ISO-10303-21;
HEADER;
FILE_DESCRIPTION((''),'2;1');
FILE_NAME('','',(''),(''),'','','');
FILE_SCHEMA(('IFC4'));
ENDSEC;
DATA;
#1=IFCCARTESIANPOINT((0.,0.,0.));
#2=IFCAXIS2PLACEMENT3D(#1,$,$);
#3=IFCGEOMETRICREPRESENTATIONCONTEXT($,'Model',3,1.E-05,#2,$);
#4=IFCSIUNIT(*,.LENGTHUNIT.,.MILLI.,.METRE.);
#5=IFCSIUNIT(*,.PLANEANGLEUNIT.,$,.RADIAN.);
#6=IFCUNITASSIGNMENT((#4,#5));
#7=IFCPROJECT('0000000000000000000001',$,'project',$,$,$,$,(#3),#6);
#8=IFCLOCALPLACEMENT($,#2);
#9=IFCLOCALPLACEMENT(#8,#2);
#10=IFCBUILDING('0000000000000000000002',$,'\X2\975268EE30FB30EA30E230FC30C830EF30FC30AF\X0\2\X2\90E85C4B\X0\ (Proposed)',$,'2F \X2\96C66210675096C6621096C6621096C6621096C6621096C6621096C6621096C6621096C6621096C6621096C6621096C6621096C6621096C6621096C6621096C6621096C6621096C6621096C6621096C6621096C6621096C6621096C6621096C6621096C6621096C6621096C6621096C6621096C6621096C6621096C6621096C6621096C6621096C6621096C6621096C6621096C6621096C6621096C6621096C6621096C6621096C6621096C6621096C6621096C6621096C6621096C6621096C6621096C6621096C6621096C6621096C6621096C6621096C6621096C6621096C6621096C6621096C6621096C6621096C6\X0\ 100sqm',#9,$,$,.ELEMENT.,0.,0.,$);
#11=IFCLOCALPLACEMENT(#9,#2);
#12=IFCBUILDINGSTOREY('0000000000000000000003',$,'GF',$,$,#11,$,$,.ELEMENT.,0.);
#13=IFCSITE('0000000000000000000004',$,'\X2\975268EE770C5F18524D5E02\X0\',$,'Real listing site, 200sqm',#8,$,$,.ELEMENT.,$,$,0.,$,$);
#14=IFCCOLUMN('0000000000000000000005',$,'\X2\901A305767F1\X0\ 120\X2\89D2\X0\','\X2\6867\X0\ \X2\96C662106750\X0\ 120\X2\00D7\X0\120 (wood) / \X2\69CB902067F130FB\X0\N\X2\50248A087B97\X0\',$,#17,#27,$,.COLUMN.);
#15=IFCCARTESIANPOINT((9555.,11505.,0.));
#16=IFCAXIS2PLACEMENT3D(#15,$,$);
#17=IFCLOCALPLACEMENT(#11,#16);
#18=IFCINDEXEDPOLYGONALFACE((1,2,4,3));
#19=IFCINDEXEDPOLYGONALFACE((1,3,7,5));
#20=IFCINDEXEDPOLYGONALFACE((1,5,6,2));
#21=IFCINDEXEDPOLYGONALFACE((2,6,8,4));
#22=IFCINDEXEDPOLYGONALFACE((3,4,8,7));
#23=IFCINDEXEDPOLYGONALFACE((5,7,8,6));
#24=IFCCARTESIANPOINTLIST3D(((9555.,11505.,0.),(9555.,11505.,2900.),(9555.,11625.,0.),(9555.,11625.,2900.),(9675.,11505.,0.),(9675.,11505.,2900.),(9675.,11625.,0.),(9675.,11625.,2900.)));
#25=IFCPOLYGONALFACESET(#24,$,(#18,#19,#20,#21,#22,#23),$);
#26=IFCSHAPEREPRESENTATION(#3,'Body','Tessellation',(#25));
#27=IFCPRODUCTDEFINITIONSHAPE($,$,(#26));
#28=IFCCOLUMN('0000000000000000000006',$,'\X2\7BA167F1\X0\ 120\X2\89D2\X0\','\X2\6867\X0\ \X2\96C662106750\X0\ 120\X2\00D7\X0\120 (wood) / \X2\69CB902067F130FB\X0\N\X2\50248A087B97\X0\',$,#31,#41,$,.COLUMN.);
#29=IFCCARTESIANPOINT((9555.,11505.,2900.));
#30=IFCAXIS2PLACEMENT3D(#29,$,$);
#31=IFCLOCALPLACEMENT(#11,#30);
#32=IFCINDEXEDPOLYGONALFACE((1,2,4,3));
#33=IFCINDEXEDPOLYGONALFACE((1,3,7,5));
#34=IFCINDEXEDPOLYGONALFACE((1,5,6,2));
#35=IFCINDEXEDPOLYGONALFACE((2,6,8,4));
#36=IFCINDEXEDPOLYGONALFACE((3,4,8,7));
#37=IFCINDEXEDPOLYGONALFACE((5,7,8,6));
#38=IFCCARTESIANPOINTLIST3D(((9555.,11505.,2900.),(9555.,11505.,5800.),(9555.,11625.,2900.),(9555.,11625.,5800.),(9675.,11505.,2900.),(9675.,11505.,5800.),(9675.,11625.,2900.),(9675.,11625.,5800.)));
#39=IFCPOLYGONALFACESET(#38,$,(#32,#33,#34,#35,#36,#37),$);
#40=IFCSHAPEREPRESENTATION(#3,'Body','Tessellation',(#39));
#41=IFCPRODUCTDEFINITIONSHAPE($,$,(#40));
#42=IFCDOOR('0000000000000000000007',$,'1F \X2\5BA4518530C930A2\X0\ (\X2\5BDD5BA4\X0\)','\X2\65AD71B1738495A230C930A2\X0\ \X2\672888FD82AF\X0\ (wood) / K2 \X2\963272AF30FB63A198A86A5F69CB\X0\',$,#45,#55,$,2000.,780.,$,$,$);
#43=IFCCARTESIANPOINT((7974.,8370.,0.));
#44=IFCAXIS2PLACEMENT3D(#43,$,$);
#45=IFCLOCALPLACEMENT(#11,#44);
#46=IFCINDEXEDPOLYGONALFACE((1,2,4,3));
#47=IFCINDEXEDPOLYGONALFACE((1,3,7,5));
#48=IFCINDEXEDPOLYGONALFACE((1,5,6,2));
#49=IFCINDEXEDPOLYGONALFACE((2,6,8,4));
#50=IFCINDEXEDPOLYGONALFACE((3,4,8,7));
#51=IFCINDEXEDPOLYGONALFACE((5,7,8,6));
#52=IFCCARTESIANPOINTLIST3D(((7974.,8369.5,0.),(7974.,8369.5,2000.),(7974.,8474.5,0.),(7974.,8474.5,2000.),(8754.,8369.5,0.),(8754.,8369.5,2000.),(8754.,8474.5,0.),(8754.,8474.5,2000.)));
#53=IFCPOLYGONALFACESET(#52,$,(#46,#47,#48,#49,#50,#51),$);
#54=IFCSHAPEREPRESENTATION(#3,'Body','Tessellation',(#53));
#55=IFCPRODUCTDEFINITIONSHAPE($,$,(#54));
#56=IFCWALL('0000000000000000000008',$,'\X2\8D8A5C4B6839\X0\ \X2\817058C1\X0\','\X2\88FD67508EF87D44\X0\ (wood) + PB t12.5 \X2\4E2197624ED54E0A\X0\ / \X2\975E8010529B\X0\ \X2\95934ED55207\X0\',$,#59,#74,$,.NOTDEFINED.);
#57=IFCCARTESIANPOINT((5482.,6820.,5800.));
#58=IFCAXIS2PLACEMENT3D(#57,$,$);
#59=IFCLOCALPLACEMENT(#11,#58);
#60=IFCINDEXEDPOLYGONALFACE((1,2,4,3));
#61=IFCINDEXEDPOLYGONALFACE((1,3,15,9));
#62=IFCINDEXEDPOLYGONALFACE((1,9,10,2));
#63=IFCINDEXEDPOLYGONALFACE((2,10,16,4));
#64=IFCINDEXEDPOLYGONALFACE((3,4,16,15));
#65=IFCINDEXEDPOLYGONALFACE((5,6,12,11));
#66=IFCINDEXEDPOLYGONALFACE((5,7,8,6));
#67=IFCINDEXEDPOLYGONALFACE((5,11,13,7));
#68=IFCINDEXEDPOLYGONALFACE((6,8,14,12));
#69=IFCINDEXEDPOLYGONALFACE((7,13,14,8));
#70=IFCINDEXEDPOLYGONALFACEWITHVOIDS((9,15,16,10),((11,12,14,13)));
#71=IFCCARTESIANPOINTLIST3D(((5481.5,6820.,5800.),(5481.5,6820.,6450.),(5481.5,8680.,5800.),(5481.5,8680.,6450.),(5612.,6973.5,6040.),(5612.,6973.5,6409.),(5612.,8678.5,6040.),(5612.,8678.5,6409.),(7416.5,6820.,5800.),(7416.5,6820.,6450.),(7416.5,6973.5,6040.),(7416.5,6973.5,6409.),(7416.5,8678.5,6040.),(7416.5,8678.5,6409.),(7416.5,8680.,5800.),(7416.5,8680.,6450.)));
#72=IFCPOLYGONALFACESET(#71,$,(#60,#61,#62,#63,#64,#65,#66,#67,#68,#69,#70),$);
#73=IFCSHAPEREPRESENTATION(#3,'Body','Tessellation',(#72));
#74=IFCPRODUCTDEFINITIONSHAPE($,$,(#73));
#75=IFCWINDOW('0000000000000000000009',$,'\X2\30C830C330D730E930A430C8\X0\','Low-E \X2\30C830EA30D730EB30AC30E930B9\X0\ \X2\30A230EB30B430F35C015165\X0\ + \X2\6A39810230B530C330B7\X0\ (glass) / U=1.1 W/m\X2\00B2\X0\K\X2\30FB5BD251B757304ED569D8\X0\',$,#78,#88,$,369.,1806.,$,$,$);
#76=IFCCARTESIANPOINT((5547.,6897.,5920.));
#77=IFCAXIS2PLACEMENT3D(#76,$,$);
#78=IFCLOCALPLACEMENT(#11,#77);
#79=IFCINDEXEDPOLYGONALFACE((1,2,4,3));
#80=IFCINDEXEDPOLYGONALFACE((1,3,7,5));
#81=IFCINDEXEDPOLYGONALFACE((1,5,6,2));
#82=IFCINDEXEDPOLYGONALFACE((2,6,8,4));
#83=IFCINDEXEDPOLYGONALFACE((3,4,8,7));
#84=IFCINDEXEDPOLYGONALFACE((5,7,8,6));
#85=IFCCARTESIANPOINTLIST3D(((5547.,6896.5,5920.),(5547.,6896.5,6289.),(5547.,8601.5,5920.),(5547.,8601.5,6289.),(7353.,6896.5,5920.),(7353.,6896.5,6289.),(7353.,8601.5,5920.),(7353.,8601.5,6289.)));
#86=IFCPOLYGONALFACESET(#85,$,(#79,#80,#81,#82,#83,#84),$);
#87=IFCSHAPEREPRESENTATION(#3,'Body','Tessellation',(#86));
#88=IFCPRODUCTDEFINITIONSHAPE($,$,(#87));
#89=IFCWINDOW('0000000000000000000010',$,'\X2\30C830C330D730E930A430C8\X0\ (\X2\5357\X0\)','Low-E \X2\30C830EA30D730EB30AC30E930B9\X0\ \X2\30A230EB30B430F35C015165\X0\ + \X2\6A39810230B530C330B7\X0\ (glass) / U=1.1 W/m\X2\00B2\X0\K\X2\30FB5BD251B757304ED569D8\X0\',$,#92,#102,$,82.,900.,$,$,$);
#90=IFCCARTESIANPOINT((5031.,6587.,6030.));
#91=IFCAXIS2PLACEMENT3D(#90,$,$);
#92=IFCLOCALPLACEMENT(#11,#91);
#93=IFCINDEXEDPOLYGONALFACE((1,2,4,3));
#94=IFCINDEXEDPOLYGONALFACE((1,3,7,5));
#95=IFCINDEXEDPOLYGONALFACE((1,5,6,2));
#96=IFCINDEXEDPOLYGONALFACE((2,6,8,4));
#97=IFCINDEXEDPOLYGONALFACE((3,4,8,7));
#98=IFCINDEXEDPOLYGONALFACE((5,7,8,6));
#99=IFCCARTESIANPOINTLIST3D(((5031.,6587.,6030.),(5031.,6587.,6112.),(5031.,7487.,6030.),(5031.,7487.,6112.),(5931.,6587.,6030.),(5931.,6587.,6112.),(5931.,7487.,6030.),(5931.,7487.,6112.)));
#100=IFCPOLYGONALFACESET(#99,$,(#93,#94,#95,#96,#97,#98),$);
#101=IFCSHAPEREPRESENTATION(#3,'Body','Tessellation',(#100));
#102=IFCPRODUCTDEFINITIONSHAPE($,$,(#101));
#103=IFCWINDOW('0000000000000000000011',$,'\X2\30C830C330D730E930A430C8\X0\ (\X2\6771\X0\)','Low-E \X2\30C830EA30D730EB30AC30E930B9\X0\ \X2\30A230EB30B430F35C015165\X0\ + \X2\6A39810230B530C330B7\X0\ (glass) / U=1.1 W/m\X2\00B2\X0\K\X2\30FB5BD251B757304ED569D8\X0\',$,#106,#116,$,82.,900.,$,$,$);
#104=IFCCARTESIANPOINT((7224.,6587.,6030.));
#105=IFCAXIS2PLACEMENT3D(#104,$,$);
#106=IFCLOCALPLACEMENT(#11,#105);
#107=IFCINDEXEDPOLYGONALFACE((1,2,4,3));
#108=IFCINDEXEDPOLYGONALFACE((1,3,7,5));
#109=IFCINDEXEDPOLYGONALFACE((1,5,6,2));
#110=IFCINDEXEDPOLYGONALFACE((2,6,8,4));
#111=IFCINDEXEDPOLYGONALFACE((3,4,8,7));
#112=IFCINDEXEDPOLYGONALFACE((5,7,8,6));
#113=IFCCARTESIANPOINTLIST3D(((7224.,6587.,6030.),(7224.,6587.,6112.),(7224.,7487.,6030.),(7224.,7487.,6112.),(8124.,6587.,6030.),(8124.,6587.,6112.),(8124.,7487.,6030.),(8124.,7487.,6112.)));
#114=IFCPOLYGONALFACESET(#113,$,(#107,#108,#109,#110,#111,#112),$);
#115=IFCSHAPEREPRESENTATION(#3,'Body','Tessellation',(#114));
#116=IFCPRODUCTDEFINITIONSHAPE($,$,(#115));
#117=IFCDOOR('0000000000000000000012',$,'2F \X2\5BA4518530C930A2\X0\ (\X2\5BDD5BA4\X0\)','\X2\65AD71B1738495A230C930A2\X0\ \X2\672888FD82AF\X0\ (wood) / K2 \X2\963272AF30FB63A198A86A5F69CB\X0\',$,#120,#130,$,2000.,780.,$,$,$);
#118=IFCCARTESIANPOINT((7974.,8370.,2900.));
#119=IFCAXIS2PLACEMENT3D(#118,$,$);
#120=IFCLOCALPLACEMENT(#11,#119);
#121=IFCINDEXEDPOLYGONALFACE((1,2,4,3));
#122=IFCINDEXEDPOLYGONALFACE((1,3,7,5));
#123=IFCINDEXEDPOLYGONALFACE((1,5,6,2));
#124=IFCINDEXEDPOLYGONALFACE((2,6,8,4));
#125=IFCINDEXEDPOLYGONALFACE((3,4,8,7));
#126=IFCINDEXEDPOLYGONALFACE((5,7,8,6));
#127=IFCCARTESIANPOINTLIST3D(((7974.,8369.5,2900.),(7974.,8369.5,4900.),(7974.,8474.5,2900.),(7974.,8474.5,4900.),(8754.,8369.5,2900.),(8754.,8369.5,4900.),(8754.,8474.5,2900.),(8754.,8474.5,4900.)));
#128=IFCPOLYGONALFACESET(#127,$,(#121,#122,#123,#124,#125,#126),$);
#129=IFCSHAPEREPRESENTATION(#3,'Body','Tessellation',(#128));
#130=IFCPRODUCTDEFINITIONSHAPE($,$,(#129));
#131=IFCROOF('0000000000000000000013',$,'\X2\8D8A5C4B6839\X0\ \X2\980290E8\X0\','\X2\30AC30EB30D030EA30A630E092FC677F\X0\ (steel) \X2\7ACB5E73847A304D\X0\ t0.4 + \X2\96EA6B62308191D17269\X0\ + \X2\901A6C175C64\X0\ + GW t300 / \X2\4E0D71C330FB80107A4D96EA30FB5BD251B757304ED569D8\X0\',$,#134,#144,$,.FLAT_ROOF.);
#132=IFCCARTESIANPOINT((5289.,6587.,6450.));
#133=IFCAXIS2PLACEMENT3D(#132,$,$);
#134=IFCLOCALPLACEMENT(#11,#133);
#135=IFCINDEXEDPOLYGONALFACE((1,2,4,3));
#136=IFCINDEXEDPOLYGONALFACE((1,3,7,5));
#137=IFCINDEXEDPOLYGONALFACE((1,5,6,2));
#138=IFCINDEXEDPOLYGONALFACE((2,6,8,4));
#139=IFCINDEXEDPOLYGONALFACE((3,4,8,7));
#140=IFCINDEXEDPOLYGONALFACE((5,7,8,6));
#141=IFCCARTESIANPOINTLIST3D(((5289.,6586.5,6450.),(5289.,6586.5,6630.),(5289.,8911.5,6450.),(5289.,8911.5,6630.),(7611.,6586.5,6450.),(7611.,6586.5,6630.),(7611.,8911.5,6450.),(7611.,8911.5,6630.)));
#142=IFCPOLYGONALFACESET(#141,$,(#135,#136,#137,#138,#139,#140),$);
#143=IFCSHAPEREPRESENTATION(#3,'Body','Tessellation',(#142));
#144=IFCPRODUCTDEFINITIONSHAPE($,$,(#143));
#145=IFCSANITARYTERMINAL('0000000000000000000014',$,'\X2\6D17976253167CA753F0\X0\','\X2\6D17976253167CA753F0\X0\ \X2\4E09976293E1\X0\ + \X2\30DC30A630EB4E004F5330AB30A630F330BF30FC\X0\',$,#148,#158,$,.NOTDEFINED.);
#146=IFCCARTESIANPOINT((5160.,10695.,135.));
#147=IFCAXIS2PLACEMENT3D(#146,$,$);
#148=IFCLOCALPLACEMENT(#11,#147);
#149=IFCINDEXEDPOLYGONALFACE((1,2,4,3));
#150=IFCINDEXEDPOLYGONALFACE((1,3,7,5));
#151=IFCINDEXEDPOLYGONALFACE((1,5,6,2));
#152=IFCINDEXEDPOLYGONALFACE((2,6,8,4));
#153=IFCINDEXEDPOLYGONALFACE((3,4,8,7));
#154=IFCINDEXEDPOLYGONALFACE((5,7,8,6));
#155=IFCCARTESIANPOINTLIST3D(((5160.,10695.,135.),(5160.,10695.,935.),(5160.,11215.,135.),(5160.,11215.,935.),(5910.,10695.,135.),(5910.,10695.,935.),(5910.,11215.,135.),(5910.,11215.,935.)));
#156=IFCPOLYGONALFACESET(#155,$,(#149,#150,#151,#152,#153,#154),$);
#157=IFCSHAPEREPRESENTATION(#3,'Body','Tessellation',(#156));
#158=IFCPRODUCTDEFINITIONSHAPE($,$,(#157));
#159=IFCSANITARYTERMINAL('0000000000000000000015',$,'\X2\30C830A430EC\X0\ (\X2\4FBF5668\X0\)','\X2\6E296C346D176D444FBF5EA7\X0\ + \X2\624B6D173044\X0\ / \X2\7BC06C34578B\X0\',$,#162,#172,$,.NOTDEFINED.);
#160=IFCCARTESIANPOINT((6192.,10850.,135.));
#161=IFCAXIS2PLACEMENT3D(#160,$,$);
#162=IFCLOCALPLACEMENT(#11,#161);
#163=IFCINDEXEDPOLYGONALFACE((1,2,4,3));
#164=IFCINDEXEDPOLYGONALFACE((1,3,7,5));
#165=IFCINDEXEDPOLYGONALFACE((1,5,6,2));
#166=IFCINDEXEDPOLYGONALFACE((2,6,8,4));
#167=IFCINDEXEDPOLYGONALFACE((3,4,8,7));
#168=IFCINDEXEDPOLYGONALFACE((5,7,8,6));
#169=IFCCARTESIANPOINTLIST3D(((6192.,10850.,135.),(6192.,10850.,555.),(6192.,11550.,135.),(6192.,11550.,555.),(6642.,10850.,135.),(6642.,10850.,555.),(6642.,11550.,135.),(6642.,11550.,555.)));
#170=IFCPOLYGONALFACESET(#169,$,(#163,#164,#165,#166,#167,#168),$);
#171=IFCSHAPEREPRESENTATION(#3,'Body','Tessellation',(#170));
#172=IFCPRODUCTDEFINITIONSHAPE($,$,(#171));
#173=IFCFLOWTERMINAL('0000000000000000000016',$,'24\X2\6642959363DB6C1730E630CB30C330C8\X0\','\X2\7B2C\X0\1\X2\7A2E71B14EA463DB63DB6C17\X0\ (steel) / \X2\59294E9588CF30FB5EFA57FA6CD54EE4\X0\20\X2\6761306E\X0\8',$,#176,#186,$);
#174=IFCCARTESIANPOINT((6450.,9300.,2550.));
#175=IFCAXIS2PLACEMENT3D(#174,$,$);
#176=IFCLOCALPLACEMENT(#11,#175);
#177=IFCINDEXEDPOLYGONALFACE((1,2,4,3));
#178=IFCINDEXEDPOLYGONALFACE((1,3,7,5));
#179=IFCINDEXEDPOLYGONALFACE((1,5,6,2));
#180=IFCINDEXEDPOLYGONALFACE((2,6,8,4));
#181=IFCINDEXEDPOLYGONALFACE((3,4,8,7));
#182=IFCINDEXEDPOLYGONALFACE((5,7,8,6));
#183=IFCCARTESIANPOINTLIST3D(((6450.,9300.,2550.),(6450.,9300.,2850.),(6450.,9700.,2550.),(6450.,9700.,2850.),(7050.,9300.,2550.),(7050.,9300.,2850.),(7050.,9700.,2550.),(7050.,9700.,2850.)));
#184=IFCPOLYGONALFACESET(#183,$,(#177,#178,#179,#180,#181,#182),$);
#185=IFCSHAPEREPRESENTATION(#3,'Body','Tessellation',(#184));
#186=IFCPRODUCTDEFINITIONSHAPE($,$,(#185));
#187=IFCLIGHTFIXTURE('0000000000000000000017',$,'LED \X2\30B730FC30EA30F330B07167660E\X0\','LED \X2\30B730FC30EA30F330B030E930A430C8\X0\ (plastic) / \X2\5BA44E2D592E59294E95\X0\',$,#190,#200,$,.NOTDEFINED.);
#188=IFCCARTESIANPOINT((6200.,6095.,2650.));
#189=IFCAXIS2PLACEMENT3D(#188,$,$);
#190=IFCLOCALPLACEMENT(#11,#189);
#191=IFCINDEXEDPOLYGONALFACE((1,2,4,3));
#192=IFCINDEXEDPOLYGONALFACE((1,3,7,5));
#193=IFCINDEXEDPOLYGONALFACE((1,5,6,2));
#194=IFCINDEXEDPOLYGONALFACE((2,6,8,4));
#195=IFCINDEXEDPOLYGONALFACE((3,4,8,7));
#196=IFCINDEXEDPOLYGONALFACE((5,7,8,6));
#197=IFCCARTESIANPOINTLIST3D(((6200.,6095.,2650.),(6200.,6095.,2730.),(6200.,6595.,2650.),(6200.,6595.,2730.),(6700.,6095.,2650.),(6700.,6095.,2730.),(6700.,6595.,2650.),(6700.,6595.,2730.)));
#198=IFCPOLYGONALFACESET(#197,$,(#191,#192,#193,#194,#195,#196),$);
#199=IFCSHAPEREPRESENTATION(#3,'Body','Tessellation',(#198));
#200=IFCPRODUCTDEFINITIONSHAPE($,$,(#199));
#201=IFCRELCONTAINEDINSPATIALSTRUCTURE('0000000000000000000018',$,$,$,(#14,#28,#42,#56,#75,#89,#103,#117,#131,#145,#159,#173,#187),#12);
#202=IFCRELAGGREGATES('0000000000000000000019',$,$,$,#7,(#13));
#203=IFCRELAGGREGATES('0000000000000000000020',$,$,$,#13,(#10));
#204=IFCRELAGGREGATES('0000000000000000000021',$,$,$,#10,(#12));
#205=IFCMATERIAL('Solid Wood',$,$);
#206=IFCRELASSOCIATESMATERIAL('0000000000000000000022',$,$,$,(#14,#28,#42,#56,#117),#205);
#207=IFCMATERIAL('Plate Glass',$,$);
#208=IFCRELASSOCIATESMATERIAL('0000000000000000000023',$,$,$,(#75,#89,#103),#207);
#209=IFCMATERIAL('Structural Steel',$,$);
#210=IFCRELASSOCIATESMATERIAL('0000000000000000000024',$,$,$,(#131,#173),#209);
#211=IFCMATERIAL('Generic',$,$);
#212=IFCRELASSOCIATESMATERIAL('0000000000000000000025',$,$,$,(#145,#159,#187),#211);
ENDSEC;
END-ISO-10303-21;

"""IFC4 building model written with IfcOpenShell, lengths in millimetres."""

from ifc_helpers import new_model, si_unit, frame, frame_2d, origin, place, context, project, spatial, rectangle, extrude, material, element, fill, save


model = new_model("IFC4")

# Units and contexts
model_context = context("Model", 3, precision=1e-05, world=origin())
ifc_project = project(units=[si_unit("LENGTHUNIT", "METRE", prefix="MILLI"), si_unit("PLANEANGLEUNIT", "RADIAN")], contexts=[model_context])

# Site, building, storey
site_placement = place(None, origin())
site = spatial("IfcSite", under=ifc_project, at=site_placement, Name="青森県弘前市", ObjectType="Real listing site, 200sqm", CompositionType="ELEMENT", RefElevation=0.0)
building_placement = place(site_placement, origin())
building = spatial("IfcBuilding", under=site, at=building_placement, Name="青森・リモートワーク2部屋 (Proposed)", ObjectType="2F 集成材集成集成集成集成集成集成集成集成集成集成集成集成集成集成集成集成集成集成集成集成集成集成集成集成集成集成集成集成集成集成集成集成集成集成集成集成集成集成集成集成集成集成集成集成集成集成集成集成集成集成集成集成集成集成集成集成集成集成集 100sqm", CompositionType="ELEMENT", ElevationOfRefHeight=0.0, ElevationOfTerrain=0.0)
storey_placement = place(building_placement, origin())
storey = spatial("IfcBuildingStorey", under=building, at=storey_placement, Name="GF", CompositionType="ELEMENT", Elevation=0.0)

# Columns
ifc_material_1 = material(Name="Solid Wood")
column_1_placement = place(storey_placement, frame((9555.0, 11505.0, 0.0)))
element("IfcColumn", 1, at=column_1_placement, inside=storey, material=ifc_material_1, Name="通し柱 120角", Description="桧 集成材 120×120 (wood) / 構造柱・N値計算", PredefinedType="COLUMN", context=model_context, shape_type="SweptSolid", body=[
    extrude(rectangle(XDim=120.0, YDim=120.0, at=frame_2d((60.0, 60.0))), frame((9555.0, 11505.0, 0.0)), (0.0, 0.0, 1.0), 2900.0),
])
column_2_placement = place(storey_placement, frame((9555.0, 11505.0, 2900.0)))
element("IfcColumn", 2, at=column_2_placement, inside=storey, material=ifc_material_1, Name="管柱 120角", Description="桧 集成材 120×120 (wood) / 構造柱・N値計算", PredefinedType="COLUMN", context=model_context, shape_type="SweptSolid", body=[
    extrude(rectangle(XDim=120.0, YDim=120.0, at=frame_2d((60.0, 60.0))), frame((9555.0, 11505.0, 2900.0)), (0.0, 0.0, 1.0), 2900.0),
])

# Door
door_1_placement = place(storey_placement, frame((7974.0, 8370.0, 0.0)))
element("IfcDoor", 3, at=door_1_placement, inside=storey, material=ifc_material_1, Name="1F 室内ドア (寝室)", Description="断熱玄関ドア 木製芯 (wood) / K2 防犯・採風機構", OverallHeight=2000.0, OverallWidth=780.0, context=model_context, shape_type="SweptSolid", body=[
    extrude(rectangle(XDim=780.0, YDim=105.0, at=frame_2d((390.0, 52.0))), frame((7974.0, 8370.0, 0.0)), (0.0, 0.0, 1.0), 2000.0),
])

# Wall, openings, windows
wall_1_placement = place(storey_placement, frame((5482.0, 6820.0, 5800.0)))
wall_1 = element("IfcWall", 4, at=wall_1_placement, inside=storey, material=ifc_material_1, Name="越屋根 腰壁", Description="製材軸組 (wood) + PB t12.5 両面仕上 / 非耐力 間仕切", PredefinedType="NOTDEFINED", context=model_context, shape_type="SweptSolid", body=[
    extrude(rectangle(XDim=1935.0, YDim=1860.0, at=frame_2d((967.0, 930.0))), frame((5482.0, 6820.0, 5800.0)), (0.0, 0.0, 1.0), 650.0),
])
opening_1_placement = place(storey_placement, frame((5547.0, 6897.0, 5920.0)))
opening_1 = element("IfcOpeningElement", 5, at=opening_1_placement, cuts=wall_1, PredefinedType="NOTDEFINED", context=model_context, shape_type="SweptSolid", body=[
    extrude(rectangle(XDim=1806.0, YDim=1705.0, at=frame_2d((903.0, 852.0))), frame((5547.0, 6897.0, 5920.0)), (0.0, 0.0, 1.0), 369.0),
])
opening_2_placement = place(storey_placement, frame((5031.0, 6587.0, 6030.0)))
opening_2 = element("IfcOpeningElement", 6, at=opening_2_placement, cuts=wall_1, PredefinedType="NOTDEFINED", context=model_context, shape_type="SweptSolid", body=[
    extrude(rectangle(XDim=900.0, YDim=900.0, at=frame_2d((450.0, 450.0))), frame((5031.0, 6587.0, 6030.0)), (0.0, 0.0, 1.0), 82.0),
])
opening_3_placement = place(storey_placement, frame((7224.0, 6587.0, 6030.0)))
opening_3 = element("IfcOpeningElement", 7, at=opening_3_placement, cuts=wall_1, PredefinedType="NOTDEFINED", context=model_context, shape_type="SweptSolid", body=[
    extrude(rectangle(XDim=900.0, YDim=900.0, at=frame_2d((450.0, 450.0))), frame((7224.0, 6587.0, 6030.0)), (0.0, 0.0, 1.0), 82.0),
])
ifc_material_2 = material(Name="Plate Glass")
window_1_placement = place(storey_placement, frame((5547.0, 6897.0, 5920.0)))
window_1 = element("IfcWindow", 8, at=window_1_placement, inside=storey, material=ifc_material_2, Name="トップライト", Description="Low-E トリプルガラス アルゴン封入 + 樹脂サッシ (glass) / U=1.1 W/m²K・寒冷地仕様", OverallHeight=369.0, OverallWidth=1806.0, context=model_context, shape_type="SweptSolid", body=[
    extrude(rectangle(XDim=1806.0, YDim=1705.0, at=frame_2d((903.0, 852.0))), frame((5547.0, 6897.0, 5920.0)), (0.0, 0.0, 1.0), 369.0),
])
fill(opening_1, window_1)
window_2_placement = place(storey_placement, frame((5031.0, 6587.0, 6030.0)))
window_2 = element("IfcWindow", 9, at=window_2_placement, inside=storey, material=ifc_material_2, Name="トップライト (南)", Description="Low-E トリプルガラス アルゴン封入 + 樹脂サッシ (glass) / U=1.1 W/m²K・寒冷地仕様", OverallHeight=82.0, OverallWidth=900.0, context=model_context, shape_type="SweptSolid", body=[
    extrude(rectangle(XDim=900.0, YDim=900.0, at=frame_2d((450.0, 450.0))), frame((5031.0, 6587.0, 6030.0)), (0.0, 0.0, 1.0), 82.0),
])
fill(opening_2, window_2)
window_3_placement = place(storey_placement, frame((7224.0, 6587.0, 6030.0)))
window_3 = element("IfcWindow", 10, at=window_3_placement, inside=storey, material=ifc_material_2, Name="トップライト (東)", Description="Low-E トリプルガラス アルゴン封入 + 樹脂サッシ (glass) / U=1.1 W/m²K・寒冷地仕様", OverallHeight=82.0, OverallWidth=900.0, context=model_context, shape_type="SweptSolid", body=[
    extrude(rectangle(XDim=900.0, YDim=900.0, at=frame_2d((450.0, 450.0))), frame((7224.0, 6587.0, 6030.0)), (0.0, 0.0, 1.0), 82.0),
])
fill(opening_3, window_3)

# Door
door_2_placement = place(storey_placement, frame((7974.0, 8370.0, 2900.0)))
element("IfcDoor", 11, at=door_2_placement, inside=storey, material=ifc_material_1, Name="2F 室内ドア (寝室)", Description="断熱玄関ドア 木製芯 (wood) / K2 防犯・採風機構", OverallHeight=2000.0, OverallWidth=780.0, context=model_context, shape_type="SweptSolid", body=[
    extrude(rectangle(XDim=780.0, YDim=105.0, at=frame_2d((390.0, 52.0))), frame((7974.0, 8370.0, 2900.0)), (0.0, 0.0, 1.0), 2000.0),
])

# Roof
ifc_material_3 = material(Name="Structural Steel")
roof_placement = place(storey_placement, frame((5289.0, 6587.0, 6450.0)))
element("IfcRoof", 12, at=roof_placement, inside=storey, material=ifc_material_3, Name="越屋根 頂部", Description="ガルバリウム鋼板 (steel) 立平葺き t0.4 + 雪止め金物 + 通気層 + GW t300 / 不燃・耐積雪・寒冷地仕様", PredefinedType="FLAT_ROOF", context=model_context, shape_type="SweptSolid", body=[
    extrude(rectangle(XDim=2322.0, YDim=2325.0, at=frame_2d((1161.0, 1162.0))), frame((5289.0, 6587.0, 6450.0)), (0.0, 0.0, 1.0), 180.0),
])

# Sanitary terminals
ifc_material_4 = material(Name="Generic")
sanitary_terminal_1_placement = place(storey_placement, frame((5160.0, 10695.0, 135.0)))
element("IfcSanitaryTerminal", 13, at=sanitary_terminal_1_placement, inside=storey, material=ifc_material_4, Name="洗面化粧台", Description="洗面化粧台 三面鏡 + ボウル一体カウンター", PredefinedType="NOTDEFINED", context=model_context, shape_type="SweptSolid", body=[
    extrude(rectangle(XDim=750.0, YDim=520.0, at=frame_2d((375.0, 260.0))), frame((5160.0, 10695.0, 135.0)), (0.0, 0.0, 1.0), 800.0),
])
sanitary_terminal_2_placement = place(storey_placement, frame((6192.0, 10850.0, 135.0)))
element("IfcSanitaryTerminal", 14, at=sanitary_terminal_2_placement, inside=storey, material=ifc_material_4, Name="トイレ (便器)", Description="温水洗浄便座 + 手洗い / 節水型", PredefinedType="NOTDEFINED", context=model_context, shape_type="SweptSolid", body=[
    extrude(rectangle(XDim=450.0, YDim=700.0, at=frame_2d((225.0, 350.0))), frame((6192.0, 10850.0, 135.0)), (0.0, 0.0, 1.0), 420.0),
])

# Flow terminal
flow_terminal_placement = place(storey_placement, frame((6450.0, 9300.0, 2550.0)))
element("IfcFlowTerminal", 15, at=flow_terminal_placement, inside=storey, material=ifc_material_3, Name="24時間換気ユニット", Description="第1種熱交換換気 (steel) / 天井裏・建基法令20条の8", context=model_context, shape_type="SweptSolid", body=[
    extrude(rectangle(XDim=600.0, YDim=400.0, at=frame_2d((300.0, 200.0))), frame((6450.0, 9300.0, 2550.0)), (0.0, 0.0, 1.0), 300.0),
])

# Light fixture
light_fixture_1_placement = place(storey_placement, frame((6200.0, 6095.0, 2650.0)))
element("IfcLightFixture", 16, at=light_fixture_1_placement, inside=storey, material=ifc_material_4, Name="LED シーリング照明", Description="LED シーリングライト (plastic) / 室中央天井", PredefinedType="NOTDEFINED", context=model_context, shape_type="SweptSolid", body=[
    extrude(rectangle(XDim=500.0, YDim=500.0, at=frame_2d((250.0, 250.0))), frame((6200.0, 6095.0, 2650.0)), (0.0, 0.0, 1.0), 80.0),
])

save(model, "model.ifc")
